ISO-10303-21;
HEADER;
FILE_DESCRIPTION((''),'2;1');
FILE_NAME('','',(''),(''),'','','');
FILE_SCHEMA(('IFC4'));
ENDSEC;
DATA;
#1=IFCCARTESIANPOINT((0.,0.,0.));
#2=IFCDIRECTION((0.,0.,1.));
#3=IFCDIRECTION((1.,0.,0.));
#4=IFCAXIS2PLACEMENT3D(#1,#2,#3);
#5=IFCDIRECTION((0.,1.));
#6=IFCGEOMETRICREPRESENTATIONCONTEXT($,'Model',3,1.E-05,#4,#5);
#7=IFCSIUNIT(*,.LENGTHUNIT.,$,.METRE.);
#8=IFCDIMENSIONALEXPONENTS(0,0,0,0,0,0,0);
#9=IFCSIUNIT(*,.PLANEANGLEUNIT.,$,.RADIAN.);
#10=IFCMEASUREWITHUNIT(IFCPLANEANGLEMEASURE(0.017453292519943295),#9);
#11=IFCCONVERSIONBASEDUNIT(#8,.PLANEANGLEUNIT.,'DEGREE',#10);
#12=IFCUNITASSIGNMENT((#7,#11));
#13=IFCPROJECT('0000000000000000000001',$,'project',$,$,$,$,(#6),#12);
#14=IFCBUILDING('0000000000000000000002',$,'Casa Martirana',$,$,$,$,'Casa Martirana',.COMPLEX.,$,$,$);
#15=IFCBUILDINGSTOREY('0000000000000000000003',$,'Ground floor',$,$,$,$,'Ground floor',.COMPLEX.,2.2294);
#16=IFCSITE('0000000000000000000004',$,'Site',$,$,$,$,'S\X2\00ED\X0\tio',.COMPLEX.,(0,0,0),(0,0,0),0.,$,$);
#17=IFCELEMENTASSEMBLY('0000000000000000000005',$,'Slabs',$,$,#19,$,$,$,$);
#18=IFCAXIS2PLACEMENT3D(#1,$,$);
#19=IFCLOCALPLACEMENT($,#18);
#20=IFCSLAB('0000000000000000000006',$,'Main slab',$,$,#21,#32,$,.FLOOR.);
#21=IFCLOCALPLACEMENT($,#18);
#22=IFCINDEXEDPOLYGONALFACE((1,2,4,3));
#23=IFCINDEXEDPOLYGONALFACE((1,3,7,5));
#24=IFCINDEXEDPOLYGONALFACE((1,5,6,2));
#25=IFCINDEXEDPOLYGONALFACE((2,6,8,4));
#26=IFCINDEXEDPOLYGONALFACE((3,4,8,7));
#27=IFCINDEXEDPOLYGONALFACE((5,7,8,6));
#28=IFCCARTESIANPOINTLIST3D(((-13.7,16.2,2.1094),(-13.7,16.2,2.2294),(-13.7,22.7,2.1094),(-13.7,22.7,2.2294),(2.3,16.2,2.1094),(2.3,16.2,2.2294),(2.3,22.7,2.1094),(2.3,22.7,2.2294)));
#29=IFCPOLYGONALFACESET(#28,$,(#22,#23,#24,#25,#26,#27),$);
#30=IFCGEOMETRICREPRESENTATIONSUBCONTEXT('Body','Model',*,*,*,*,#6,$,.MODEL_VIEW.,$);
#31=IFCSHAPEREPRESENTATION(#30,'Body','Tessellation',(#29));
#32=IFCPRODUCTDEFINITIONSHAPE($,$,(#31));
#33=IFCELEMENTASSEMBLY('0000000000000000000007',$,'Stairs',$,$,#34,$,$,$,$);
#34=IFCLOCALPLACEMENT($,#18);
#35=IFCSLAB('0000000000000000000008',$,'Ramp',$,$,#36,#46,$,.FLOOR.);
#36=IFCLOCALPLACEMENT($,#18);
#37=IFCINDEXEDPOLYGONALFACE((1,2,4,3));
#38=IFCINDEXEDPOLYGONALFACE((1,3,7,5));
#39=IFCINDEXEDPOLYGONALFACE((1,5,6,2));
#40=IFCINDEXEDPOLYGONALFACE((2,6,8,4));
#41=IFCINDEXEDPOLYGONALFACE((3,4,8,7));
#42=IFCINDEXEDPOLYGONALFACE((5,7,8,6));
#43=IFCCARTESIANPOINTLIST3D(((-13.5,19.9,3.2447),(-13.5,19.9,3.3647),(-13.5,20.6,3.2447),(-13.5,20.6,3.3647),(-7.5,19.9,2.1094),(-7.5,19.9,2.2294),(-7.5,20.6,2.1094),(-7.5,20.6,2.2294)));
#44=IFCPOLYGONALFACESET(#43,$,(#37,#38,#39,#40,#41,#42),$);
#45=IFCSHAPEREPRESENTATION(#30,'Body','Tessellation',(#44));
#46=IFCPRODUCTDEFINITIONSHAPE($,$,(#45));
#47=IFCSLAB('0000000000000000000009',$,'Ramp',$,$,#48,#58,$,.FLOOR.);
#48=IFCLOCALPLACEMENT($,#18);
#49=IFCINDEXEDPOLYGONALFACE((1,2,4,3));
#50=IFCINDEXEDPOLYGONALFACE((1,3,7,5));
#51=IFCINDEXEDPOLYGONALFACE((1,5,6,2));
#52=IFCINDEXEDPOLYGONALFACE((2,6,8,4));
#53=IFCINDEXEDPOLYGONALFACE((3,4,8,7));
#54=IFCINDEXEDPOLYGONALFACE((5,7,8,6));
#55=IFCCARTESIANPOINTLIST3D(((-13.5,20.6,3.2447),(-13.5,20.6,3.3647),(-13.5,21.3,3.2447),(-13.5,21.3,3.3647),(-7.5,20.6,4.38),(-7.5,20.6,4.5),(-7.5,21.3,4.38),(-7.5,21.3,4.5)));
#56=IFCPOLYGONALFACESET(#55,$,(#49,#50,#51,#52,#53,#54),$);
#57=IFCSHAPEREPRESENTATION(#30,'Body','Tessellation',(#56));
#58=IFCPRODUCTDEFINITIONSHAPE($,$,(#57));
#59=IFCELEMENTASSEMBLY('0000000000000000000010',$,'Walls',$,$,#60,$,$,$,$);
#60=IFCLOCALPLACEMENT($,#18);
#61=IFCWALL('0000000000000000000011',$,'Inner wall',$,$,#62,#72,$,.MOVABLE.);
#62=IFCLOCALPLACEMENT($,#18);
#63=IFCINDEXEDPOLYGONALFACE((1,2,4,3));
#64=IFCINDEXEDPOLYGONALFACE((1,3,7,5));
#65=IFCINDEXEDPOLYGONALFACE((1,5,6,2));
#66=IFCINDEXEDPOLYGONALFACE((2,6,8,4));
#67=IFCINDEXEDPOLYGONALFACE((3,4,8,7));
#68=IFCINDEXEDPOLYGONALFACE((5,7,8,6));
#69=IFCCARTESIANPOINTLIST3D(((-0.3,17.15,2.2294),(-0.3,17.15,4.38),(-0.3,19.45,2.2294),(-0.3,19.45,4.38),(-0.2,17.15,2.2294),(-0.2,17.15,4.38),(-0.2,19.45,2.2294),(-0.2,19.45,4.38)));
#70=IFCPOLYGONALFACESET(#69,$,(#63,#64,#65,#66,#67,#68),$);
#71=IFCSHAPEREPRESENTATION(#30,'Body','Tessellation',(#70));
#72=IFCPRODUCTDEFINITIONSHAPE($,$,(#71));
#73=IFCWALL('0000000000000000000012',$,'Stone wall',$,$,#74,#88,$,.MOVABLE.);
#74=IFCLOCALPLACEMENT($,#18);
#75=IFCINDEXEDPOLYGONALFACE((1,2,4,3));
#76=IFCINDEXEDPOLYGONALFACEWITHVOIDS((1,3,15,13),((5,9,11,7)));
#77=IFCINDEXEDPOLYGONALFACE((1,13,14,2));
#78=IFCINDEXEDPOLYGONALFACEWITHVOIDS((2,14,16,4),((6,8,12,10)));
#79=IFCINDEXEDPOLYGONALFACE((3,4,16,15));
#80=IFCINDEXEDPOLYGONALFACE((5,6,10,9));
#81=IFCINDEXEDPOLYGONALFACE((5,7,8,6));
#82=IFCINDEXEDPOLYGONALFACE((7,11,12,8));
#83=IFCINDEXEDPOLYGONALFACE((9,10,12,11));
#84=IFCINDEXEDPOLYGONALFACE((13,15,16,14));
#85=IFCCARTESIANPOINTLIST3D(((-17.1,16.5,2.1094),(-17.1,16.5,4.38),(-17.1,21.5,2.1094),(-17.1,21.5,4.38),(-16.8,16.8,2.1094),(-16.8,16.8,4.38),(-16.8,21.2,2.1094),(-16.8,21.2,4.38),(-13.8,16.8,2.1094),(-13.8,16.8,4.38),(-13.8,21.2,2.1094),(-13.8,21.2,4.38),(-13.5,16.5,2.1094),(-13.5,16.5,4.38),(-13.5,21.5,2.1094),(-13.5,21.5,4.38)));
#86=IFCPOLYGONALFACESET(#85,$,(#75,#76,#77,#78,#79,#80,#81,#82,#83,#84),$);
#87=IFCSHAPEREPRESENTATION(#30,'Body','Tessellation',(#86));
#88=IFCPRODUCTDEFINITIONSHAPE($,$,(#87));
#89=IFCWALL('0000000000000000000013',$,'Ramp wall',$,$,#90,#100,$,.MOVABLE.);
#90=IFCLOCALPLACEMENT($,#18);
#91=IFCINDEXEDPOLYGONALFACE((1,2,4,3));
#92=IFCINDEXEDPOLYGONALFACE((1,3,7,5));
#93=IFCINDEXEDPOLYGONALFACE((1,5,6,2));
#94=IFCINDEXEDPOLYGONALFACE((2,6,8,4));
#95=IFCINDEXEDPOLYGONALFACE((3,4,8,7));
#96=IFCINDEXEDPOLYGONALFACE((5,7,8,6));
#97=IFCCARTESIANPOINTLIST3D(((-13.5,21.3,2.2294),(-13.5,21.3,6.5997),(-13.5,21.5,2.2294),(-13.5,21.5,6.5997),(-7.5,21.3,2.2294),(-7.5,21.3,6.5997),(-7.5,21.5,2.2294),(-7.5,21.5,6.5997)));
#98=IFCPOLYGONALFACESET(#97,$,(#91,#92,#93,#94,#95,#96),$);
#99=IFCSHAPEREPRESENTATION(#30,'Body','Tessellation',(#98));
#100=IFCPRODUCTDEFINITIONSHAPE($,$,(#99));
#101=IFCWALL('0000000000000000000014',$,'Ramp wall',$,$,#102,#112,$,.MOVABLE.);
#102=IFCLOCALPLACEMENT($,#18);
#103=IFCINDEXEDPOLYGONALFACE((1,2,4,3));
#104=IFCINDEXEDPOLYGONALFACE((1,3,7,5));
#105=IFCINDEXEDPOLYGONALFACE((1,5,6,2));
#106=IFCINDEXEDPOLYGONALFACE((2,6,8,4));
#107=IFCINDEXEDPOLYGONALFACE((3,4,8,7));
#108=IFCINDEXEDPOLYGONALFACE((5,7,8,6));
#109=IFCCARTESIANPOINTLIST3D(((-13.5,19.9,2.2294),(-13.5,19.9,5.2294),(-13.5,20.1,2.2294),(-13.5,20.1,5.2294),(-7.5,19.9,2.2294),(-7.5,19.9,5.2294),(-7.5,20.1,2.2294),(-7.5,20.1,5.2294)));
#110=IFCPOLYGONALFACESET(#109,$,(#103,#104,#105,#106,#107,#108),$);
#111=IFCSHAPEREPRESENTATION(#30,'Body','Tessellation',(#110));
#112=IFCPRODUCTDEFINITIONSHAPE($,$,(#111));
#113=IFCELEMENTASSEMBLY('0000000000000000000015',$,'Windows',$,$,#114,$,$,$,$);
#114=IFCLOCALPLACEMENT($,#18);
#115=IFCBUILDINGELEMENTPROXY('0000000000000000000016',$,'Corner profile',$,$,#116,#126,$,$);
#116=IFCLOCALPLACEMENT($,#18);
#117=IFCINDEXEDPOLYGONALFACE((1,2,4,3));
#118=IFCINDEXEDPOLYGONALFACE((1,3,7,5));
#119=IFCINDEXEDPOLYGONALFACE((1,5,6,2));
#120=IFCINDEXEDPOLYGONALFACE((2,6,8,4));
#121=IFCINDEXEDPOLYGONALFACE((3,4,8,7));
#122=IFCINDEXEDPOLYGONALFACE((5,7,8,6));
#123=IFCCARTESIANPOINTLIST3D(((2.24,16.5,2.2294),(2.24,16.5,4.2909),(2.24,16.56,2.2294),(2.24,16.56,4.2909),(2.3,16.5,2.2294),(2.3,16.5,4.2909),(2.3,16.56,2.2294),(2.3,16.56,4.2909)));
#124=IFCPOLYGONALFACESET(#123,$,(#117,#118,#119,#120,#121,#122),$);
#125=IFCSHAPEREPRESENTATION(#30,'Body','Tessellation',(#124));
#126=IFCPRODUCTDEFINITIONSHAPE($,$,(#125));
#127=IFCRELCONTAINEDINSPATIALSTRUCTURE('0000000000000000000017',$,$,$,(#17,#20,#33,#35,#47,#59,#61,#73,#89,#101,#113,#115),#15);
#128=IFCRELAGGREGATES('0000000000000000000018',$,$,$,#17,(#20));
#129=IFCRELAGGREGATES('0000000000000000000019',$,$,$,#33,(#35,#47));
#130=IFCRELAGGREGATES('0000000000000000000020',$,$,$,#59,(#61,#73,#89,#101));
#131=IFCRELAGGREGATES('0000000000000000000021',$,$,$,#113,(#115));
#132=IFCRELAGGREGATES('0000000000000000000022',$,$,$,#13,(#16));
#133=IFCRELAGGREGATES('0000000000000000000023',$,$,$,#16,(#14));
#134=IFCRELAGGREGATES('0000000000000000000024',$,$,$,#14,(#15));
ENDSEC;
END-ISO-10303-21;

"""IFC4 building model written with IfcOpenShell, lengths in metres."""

from ifc_helpers import new_model, entity, si_unit, converted_unit, direction, frame, frame_2d, origin_with_axes, origin_2d_with_axis, place, context, subcontext, project, spatial, polyline, rectangle, outline, extrude, source, transform, mapped, element, aggregate, save


model = new_model("IFC4")

# Units and contexts
model_context = context("Model", 3, precision=1e-05, world=origin_with_axes(), true_north=direction((0.0, 1.0)))
body_context = subcontext(model_context, "Body", "Model", "MODEL_VIEW")
ifc_project = project(units=[si_unit("LENGTHUNIT", "METRE"), converted_unit("PLANEANGLEUNIT", "DEGREE", entity("IfcPlaneAngleMeasure", 0.017453292519943295), si_unit("PLANEANGLEUNIT", "RADIAN"), dimensions=[0, 0, 0, 0, 0, 0, 0])], contexts=[model_context])

# Site, building, storey
site = spatial("IfcSite", under=ifc_project, Name="Site", LongName="Sítio", CompositionType="COMPLEX", RefLatitude=(0, 0, 0), RefLongitude=(0, 0, 0), RefElevation=0.0)
building = spatial("IfcBuilding", under=site, Name="Casa Martirana", LongName="Casa Martirana", CompositionType="COMPLEX")
storey = spatial("IfcBuildingStorey", under=building, Name="Ground floor", LongName="Ground floor", CompositionType="COMPLEX", Elevation=2.2294)

# Element assembly, slab
assembly_1 = element("IfcElementAssembly", 1, inside=storey, Name="Slabs")
placement = place(None, origin_with_axes())
slab_1 = element("IfcSlab", 2, at=placement, inside=storey, Name="Main slab", PredefinedType="FLOOR", context=body_context, shape_type="SweptSolid", body=[
    extrude(rectangle(XDim=16.0, YDim=6.5, at=frame_2d((0.0, 0.0), x_axis=(1.0, 0.0))), frame((-5.7, 19.45, 2.2294), z_axis=(0.0, 0.0, 1.0), x_axis=(1.0, 0.0, 0.0)), (0.0, 0.0, -1.0), 0.12),
])
aggregate(assembly_1, [slab_1])

# Element assembly, slabs
assembly_2 = element("IfcElementAssembly", 3, inside=storey, Name="Stairs")
slab_2 = element("IfcSlab", 4, at=placement, inside=storey, Name="Ramp", PredefinedType="FLOOR", context=body_context, shape_type="SweptSolid", body=[
    extrude(rectangle(XDim=0.7, YDim=6.1065, at=frame_2d((0.0, 0.0), x_axis=(0.0, -1.0))), frame((-10.5, 20.25, 2.797), z_axis=(-0.185919, 0.0, -0.982565), x_axis=(-0.982565, 0.0, 0.185919)), (-0.185919, 0.0, 0.982565), 0.12),
])
slab_3 = element("IfcSlab", 5, at=placement, inside=storey, Name="Ramp", PredefinedType="FLOOR", context=body_context, shape_type="SweptSolid", body=[
    extrude(rectangle(XDim=0.7, YDim=6.1065, at=frame_2d((0.0, 0.0), x_axis=(0.0, -1.0))), frame((-10.5, 20.95, 3.9323), z_axis=(-0.185919, 0.0, 0.982565), x_axis=(0.982565, 0.0, 0.185919)), (-0.185919, 0.0, -0.982565), 0.12),
])
aggregate(assembly_2, [slab_2, slab_3])

# Element assembly, walls
assembly_3 = element("IfcElementAssembly", 6, inside=storey, Name="Walls")
wall_1 = element("IfcWall", 7, at=placement, inside=storey, Name="Inner wall", PredefinedType="MOVABLE", context=body_context, shape_type="SweptSolid", body=[
    extrude(rectangle(XDim=2.3, YDim=0.1, at=frame_2d((0.0, 0.0), x_axis=(0.0, 1.0))), frame((-0.25, 18.3, 2.2294), z_axis=(0.0, 0.0, 1.0), x_axis=(1.0, 0.0, 0.0)), (0.0, 0.0, 1.0), 2.1506),
])
wall_2 = element("IfcWall", 8, at=placement, inside=storey, Name="Stone wall", PredefinedType="MOVABLE", context=body_context, shape_type="SweptSolid", body=[
    extrude(outline(polyline([(-1.8, -2.5), (1.8, -2.5), (1.8, 2.5), (-1.8, 2.5), (-1.8, -2.5)]), holes=[polyline([(1.5, 2.2), (-1.5, 2.2), (-1.5, -2.2), (1.5, -2.2), (1.5, 2.2)])]), frame((-15.3, 19.0, 2.1094), z_axis=(0.0, 0.0, 1.0), x_axis=(1.0, 0.0, 0.0)), (0.0, 0.0, 1.0), 2.2706),
])
wall_3 = element("IfcWall", 9, at=placement, inside=storey, Name="Ramp wall", PredefinedType="MOVABLE", context=body_context, shape_type="SweptSolid", body=[
    extrude(rectangle(XDim=6.0, YDim=0.2, at=origin_2d_with_axis()), frame((-10.5, 21.4, 2.2294), z_axis=(0.0, 0.0, 1.0), x_axis=(1.0, 0.0, 0.0)), (0.0, 0.0, 1.0), 4.3703),
])
wall_4 = element("IfcWall", 10, at=placement, inside=storey, Name="Ramp wall", PredefinedType="MOVABLE", context=body_context, shape_type="SweptSolid", body=[
    extrude(rectangle(XDim=6.0, YDim=0.2, at=origin_2d_with_axis()), frame((-10.5, 20.0, 2.2294), z_axis=(0.0, 0.0, 1.0), x_axis=(1.0, 0.0, 0.0)), (0.0, 0.0, 1.0), 3.0),
])
aggregate(assembly_3, [wall_1, wall_2, wall_3, wall_4])

# Element assembly, building element proxy
assembly_4 = element("IfcElementAssembly", 11, inside=storey, Name="Windows")
shared_shape = source(origin_with_axes(), body_context, "Body", "SweptSolid", [
    extrude(rectangle(XDim=0.06, YDim=0.06, at=origin_2d_with_axis()), frame((2.27, 16.53, 2.2294), z_axis=(0.0, 0.0, 1.0), x_axis=(1.0, 0.0, 0.0)), (0.0, 0.0, 1.0), 2.0615),
])
proxy_1 = element("IfcBuildingElementProxy", 12, at=placement, inside=storey, Name="Corner profile", context=body_context, shape_type="MappedRepresentation", body=[
    mapped(shared_shape, transform((0.0, 0.0, 0.0), x_axis=(1.0, 0.0, 0.0), y_axis=(0.0, 1.0, 0.0), z_axis=(0.0, 0.0, 1.0), scale=1.0)),
])
aggregate(assembly_4, [proxy_1])

save(model, "model.ifc")
